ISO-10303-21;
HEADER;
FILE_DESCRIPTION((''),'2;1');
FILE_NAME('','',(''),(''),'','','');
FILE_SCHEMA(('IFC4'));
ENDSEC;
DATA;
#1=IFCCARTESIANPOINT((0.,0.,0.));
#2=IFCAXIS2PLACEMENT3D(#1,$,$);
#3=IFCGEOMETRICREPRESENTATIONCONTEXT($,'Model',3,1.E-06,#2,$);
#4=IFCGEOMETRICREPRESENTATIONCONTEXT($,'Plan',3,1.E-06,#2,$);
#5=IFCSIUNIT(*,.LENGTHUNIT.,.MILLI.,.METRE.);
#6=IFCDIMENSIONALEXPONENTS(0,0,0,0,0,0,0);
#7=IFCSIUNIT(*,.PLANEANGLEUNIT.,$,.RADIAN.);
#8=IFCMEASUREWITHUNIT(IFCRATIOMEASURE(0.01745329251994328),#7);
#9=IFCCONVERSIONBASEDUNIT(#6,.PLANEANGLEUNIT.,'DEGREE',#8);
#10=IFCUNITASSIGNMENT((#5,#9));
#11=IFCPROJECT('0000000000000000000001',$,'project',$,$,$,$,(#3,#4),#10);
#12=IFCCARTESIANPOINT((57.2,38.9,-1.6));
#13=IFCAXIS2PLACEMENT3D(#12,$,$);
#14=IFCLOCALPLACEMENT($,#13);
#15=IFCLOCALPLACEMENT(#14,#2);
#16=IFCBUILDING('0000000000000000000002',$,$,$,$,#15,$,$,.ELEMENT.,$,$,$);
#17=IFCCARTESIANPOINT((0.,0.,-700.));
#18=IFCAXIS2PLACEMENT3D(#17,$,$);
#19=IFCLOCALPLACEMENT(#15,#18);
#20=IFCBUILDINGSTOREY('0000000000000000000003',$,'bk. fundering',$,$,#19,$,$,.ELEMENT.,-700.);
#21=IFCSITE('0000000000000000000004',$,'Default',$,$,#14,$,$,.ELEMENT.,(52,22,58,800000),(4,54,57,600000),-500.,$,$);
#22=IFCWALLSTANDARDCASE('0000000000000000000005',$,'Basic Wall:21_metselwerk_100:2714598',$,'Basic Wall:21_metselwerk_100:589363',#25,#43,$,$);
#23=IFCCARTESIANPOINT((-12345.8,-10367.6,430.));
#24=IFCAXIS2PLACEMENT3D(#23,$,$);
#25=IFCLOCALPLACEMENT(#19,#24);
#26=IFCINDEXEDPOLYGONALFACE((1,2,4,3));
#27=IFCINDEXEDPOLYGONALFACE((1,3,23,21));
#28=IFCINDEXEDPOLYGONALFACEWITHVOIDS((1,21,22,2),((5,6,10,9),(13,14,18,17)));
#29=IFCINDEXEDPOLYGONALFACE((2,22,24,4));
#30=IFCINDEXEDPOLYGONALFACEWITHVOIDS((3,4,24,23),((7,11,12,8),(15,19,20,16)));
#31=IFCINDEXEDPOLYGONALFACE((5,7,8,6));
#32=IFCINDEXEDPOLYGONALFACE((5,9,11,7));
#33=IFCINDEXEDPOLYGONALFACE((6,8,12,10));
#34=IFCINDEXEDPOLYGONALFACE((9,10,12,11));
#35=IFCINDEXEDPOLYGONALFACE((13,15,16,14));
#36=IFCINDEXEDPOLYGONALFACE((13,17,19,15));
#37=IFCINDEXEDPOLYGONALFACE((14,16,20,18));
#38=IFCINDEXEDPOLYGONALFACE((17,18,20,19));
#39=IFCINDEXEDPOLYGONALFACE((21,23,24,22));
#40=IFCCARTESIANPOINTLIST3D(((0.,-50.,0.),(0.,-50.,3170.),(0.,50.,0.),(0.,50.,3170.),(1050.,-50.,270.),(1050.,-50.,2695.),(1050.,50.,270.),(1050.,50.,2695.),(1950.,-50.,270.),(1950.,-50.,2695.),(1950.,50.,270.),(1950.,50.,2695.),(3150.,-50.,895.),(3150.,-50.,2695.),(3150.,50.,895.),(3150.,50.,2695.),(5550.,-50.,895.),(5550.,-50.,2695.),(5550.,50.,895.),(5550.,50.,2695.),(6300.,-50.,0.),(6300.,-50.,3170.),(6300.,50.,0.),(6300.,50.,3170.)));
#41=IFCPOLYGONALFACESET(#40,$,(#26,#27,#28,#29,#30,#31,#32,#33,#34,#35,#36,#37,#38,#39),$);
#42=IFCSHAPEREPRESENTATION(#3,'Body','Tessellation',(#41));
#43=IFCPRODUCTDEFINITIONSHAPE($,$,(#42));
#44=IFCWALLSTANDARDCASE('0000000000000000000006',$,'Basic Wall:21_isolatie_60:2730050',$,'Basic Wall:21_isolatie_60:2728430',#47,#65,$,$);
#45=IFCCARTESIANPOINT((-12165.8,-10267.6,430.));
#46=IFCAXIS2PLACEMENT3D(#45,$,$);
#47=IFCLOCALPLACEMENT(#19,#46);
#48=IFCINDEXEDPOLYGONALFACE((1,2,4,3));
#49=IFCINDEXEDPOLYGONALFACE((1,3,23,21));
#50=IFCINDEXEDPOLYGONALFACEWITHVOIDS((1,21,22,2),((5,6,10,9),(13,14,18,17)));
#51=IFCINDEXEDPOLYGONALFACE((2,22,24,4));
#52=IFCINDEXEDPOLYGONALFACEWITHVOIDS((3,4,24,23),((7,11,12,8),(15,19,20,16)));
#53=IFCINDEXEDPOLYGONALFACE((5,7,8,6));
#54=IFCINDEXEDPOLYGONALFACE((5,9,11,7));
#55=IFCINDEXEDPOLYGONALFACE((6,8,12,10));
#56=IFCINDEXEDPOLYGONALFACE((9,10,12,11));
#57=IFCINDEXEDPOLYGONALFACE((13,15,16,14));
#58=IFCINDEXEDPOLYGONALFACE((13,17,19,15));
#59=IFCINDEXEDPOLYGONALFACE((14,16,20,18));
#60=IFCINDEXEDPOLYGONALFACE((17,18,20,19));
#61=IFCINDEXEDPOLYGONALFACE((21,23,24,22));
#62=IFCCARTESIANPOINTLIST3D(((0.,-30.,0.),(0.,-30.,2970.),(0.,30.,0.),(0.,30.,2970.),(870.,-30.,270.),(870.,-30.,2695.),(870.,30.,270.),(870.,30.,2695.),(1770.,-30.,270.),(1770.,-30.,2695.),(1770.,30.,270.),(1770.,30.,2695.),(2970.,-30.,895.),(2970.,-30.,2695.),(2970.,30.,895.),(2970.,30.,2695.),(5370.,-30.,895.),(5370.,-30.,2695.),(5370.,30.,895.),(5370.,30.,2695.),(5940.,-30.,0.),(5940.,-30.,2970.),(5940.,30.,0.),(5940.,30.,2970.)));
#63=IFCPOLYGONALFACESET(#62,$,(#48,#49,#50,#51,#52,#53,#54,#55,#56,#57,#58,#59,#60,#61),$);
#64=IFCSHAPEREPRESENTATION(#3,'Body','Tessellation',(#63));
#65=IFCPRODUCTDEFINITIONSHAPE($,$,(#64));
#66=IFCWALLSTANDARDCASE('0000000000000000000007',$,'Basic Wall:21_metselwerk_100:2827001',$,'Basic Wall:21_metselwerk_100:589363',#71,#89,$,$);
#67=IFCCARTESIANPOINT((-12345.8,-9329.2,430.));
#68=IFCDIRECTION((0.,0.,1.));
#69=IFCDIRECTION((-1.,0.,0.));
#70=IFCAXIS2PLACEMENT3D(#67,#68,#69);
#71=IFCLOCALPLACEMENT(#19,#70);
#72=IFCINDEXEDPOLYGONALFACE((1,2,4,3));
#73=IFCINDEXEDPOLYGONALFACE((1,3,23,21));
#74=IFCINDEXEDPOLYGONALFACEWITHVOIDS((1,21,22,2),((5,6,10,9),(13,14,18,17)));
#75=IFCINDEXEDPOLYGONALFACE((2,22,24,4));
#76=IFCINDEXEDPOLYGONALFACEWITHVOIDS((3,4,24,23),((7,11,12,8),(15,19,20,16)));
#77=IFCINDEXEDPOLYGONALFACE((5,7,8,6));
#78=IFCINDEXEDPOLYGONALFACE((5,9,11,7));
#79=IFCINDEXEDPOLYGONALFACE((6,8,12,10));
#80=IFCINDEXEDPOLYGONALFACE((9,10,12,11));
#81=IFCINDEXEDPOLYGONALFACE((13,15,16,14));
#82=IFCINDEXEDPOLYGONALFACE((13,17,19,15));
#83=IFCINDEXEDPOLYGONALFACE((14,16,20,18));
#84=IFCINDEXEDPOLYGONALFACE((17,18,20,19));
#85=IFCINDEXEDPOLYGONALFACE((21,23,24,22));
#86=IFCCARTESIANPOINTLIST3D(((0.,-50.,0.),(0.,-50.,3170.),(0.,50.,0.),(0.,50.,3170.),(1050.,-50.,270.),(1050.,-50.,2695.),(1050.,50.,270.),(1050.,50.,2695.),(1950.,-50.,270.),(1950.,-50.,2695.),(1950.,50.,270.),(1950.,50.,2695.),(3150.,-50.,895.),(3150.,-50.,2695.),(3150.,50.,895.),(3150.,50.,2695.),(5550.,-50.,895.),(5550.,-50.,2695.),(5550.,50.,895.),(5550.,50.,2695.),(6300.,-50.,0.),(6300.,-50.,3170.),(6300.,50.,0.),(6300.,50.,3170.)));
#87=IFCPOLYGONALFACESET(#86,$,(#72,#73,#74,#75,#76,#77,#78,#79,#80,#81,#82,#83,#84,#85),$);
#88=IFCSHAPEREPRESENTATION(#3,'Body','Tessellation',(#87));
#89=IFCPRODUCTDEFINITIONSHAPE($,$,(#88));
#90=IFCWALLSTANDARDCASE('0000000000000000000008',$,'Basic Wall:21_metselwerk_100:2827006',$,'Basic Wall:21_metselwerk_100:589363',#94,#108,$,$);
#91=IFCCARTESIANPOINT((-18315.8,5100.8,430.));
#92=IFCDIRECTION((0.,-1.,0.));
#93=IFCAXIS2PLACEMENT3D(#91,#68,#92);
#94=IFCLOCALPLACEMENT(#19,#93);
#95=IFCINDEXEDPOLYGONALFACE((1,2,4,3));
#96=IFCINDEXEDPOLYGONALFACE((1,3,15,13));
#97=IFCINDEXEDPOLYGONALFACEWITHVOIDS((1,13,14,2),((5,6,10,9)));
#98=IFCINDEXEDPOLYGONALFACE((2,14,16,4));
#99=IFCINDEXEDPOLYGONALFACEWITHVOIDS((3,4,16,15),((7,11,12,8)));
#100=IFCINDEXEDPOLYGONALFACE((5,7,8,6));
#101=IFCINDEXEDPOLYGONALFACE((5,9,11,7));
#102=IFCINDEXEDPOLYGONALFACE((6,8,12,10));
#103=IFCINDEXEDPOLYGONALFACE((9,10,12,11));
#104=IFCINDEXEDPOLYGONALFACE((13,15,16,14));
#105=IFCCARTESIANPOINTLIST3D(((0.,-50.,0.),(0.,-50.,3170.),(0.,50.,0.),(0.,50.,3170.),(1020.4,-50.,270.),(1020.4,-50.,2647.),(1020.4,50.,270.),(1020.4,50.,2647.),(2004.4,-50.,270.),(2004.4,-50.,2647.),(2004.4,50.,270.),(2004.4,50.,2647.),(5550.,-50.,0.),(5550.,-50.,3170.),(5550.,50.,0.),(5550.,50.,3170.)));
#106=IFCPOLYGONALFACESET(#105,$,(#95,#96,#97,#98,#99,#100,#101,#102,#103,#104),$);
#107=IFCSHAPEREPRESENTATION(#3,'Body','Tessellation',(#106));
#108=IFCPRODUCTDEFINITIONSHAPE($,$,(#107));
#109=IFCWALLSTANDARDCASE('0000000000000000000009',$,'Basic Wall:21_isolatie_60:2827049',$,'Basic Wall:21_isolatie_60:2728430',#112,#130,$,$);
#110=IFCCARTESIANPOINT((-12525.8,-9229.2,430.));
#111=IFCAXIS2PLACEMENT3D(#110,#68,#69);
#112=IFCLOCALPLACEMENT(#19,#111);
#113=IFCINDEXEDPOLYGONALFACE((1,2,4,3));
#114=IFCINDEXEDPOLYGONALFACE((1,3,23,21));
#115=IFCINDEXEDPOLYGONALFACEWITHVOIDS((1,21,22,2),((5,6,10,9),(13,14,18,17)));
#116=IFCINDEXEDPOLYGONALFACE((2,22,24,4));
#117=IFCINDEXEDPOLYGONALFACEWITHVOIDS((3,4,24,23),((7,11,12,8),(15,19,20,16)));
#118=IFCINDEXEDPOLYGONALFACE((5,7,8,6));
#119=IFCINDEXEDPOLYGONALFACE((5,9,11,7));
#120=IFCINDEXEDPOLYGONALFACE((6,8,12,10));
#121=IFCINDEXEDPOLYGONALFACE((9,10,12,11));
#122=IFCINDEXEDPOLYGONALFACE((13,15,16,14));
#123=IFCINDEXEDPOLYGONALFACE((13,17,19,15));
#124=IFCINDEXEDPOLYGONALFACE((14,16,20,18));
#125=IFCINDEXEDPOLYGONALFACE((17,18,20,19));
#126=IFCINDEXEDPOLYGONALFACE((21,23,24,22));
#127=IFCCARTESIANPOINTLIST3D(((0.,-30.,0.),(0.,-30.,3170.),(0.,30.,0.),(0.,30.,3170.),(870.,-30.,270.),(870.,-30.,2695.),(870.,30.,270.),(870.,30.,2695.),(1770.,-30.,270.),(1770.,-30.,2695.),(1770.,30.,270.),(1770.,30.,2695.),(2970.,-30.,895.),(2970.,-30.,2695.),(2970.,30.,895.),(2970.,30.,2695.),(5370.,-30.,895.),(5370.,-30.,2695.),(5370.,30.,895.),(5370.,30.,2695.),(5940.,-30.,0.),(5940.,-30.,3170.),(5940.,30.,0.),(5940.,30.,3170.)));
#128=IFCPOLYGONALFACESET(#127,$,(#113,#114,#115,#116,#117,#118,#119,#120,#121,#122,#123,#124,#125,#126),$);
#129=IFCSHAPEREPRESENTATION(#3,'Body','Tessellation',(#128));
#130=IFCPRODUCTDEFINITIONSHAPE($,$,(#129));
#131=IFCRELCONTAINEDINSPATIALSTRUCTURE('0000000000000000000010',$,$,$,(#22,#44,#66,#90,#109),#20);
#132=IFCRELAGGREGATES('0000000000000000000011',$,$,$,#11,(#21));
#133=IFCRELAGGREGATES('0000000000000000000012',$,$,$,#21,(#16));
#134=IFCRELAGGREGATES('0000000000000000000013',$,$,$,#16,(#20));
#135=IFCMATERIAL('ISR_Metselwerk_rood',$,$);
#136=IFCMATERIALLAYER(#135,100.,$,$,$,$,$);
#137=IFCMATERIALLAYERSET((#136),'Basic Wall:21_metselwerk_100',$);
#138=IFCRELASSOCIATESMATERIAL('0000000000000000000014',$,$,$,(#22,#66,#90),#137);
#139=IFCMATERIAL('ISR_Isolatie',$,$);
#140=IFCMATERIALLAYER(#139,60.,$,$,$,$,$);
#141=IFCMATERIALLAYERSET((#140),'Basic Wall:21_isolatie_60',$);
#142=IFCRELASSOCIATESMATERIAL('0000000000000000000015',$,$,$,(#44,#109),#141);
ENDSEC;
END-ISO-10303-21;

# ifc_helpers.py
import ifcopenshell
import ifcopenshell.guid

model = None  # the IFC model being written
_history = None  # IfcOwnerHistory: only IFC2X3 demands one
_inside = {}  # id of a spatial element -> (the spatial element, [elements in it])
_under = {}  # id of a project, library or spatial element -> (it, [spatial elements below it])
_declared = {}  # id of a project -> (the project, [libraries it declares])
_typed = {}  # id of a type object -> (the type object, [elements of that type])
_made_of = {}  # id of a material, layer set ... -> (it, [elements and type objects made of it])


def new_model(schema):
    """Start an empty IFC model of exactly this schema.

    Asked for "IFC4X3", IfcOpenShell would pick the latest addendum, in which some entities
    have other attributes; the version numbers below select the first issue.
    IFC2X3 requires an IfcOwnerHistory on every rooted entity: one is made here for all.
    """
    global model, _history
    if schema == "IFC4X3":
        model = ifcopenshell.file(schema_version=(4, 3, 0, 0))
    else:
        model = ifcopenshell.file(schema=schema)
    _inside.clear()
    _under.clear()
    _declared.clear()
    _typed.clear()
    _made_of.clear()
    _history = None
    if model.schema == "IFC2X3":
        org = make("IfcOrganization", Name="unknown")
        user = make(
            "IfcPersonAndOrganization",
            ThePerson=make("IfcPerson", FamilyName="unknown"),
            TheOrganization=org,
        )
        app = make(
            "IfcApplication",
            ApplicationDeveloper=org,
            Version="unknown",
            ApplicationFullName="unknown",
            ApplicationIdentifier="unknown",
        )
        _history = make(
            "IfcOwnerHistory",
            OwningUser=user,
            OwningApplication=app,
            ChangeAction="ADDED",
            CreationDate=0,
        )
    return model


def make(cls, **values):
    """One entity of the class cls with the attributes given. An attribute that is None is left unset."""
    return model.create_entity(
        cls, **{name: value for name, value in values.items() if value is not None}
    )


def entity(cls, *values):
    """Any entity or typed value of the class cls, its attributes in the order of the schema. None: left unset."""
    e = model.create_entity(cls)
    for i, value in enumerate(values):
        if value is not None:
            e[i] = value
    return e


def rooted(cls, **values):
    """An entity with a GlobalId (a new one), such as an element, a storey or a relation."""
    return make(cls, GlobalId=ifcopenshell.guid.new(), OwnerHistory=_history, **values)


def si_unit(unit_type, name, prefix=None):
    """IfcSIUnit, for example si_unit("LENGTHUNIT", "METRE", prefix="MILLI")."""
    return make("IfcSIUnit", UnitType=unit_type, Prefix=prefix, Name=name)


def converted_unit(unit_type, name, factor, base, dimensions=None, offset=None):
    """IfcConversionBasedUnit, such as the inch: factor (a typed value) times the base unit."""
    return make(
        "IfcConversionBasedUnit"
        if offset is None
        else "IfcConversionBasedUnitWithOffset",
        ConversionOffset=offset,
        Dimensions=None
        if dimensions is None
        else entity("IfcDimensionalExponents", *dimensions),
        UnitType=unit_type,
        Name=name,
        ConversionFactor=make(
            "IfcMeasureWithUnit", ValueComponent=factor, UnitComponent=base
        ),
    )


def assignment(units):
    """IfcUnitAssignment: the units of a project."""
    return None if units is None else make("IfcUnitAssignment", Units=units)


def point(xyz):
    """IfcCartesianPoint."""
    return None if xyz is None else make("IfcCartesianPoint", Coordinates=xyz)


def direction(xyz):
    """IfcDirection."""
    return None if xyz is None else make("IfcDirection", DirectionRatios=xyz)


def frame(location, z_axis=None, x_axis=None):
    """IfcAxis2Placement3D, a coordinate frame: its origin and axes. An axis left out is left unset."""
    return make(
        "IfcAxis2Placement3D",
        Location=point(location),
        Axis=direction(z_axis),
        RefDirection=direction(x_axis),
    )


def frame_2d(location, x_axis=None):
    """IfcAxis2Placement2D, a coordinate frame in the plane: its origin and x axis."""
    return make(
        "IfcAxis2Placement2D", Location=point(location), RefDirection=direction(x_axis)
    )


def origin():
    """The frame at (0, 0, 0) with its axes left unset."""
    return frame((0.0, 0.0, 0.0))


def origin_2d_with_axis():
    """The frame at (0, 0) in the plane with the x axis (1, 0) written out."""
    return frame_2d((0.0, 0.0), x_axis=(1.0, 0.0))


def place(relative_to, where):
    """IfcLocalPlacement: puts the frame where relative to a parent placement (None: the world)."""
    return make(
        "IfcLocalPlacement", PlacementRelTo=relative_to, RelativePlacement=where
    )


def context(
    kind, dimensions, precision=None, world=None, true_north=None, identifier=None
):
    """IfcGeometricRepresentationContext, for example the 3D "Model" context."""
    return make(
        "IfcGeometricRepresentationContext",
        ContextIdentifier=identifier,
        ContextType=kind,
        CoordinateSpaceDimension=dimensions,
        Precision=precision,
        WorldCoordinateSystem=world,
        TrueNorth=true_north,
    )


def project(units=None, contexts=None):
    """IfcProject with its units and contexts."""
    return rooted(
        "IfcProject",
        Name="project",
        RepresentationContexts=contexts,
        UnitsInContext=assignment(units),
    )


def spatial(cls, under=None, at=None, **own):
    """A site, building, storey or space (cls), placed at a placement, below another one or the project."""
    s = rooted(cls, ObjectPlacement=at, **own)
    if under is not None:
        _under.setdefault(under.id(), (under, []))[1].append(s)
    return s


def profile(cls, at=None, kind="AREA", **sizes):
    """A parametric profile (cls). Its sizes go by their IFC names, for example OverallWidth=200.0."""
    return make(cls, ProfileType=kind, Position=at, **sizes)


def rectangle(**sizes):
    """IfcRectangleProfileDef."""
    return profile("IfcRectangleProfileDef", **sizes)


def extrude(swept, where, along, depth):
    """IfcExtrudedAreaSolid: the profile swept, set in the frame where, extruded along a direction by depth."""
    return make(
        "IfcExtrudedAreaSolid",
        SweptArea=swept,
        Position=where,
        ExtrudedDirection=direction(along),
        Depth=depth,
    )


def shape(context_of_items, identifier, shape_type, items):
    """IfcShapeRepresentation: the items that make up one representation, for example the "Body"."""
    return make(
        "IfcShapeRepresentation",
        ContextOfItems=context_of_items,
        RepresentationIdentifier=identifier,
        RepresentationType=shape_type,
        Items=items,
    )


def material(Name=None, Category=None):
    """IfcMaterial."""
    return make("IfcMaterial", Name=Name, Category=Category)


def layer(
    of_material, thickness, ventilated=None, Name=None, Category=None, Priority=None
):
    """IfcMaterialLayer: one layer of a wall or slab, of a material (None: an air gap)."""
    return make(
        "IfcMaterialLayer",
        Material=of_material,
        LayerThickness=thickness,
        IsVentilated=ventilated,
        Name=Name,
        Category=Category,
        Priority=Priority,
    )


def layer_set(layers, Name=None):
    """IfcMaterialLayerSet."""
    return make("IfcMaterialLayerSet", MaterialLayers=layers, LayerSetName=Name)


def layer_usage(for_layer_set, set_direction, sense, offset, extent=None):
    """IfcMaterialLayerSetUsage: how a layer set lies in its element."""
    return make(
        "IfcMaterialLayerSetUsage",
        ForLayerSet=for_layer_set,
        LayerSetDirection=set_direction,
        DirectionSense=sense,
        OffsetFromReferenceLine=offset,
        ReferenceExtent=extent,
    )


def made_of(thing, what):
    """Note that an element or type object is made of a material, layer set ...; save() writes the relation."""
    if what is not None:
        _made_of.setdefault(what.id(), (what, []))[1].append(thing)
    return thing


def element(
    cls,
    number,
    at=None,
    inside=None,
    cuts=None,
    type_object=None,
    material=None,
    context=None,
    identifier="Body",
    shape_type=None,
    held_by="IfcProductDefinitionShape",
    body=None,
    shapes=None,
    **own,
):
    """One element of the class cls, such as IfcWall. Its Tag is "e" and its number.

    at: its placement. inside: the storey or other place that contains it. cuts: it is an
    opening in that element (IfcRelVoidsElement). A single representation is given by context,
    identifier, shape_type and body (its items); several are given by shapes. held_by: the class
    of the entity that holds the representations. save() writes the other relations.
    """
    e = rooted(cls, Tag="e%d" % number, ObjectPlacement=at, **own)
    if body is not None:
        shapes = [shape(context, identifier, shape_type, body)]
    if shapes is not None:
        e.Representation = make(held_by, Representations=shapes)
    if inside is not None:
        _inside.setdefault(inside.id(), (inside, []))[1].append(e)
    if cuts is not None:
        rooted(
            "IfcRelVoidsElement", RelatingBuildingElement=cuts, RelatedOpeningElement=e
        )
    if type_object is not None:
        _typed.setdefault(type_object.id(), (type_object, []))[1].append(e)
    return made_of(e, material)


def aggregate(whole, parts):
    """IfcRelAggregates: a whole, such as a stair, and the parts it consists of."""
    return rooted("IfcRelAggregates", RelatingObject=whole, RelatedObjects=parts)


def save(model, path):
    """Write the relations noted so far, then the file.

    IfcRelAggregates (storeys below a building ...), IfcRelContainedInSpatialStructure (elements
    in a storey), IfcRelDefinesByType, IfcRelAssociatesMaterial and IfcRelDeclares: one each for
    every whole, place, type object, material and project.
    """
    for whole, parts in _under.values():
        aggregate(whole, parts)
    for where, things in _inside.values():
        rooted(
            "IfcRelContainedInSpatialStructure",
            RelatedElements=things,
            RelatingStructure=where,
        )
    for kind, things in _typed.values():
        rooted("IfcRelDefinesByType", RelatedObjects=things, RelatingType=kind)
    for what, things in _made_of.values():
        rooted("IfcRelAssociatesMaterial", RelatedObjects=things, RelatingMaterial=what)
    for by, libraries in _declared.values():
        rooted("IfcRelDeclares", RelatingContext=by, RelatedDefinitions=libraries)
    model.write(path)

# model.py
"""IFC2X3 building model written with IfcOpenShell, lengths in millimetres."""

from ifc_helpers import new_model, entity, si_unit, converted_unit, frame, frame_2d, origin, origin_2d_with_axis, place, context, project, spatial, rectangle, extrude, material, layer, layer_set, layer_usage, element, save


model = new_model("IFC2X3")

# Units and contexts
model_context = context("Model", 3, precision=1e-06, world=origin())
plan_context = context("Plan", 3, precision=1e-06, world=origin())
ifc_project = project(units=[si_unit("LENGTHUNIT", "METRE", prefix="MILLI"), converted_unit("PLANEANGLEUNIT", "DEGREE", entity("IfcRatioMeasure", 0.01745329251994328), si_unit("PLANEANGLEUNIT", "RADIAN"), dimensions=[0, 0, 0, 0, 0, 0, 0])], contexts=[model_context, plan_context])

# Site, building, storey
site_placement = place(None, frame((57.2, 38.9, -1.6)))
site = spatial("IfcSite", under=ifc_project, at=site_placement, Name="Default", CompositionType="ELEMENT", RefLatitude=(52, 22, 58, 800000), RefLongitude=(4, 54, 57, 600000), RefElevation=-500.0)
building_placement = place(site_placement, origin())
building = spatial("IfcBuilding", under=site, at=building_placement, CompositionType="ELEMENT")
storey_placement = place(building_placement, frame((0.0, 0.0, -700.0)))
storey = spatial("IfcBuildingStorey", under=building, at=storey_placement, Name="bk. fundering", CompositionType="ELEMENT", Elevation=-700.0)

# Wall, openings
ifc_material_1 = material(Name="ISR_Metselwerk_rood")
ifc_layer_1 = layer(ifc_material_1, 100.0)
ifc_layer_set_1 = layer_set([ifc_layer_1], Name="Basic Wall:21_metselwerk_100")
ifc_layer_usage_1 = layer_usage(ifc_layer_set_1, "AXIS2", "NEGATIVE", 50.0)
wall_1_placement = place(storey_placement, frame((-12345.8, -10367.6, 430.0)))
wall_1 = element("IfcWallStandardCase", 1, at=wall_1_placement, inside=storey, material=ifc_layer_usage_1, Name="Basic Wall:21_metselwerk_100:2714598", ObjectType="Basic Wall:21_metselwerk_100:589363", context=model_context, shape_type="SweptSolid", body=[
    extrude(rectangle(XDim=6300.0, YDim=100.0, at=frame_2d((3150.0, 0.0), x_axis=(-1.0, 0.0))), origin(), (0.0, 0.0, 1.0), 3170.0),
])
opening_1_placement = place(wall_1_placement, origin())
element("IfcOpeningElement", 2, at=opening_1_placement, cuts=wall_1, ObjectType="Opening", context=model_context, shape_type="SweptSolid", body=[
    extrude(rectangle(XDim=2425.0, YDim=900.0, at=origin_2d_with_axis()), frame((1500.0, -202.4, 1482.5), z_axis=(0.0, 1.0, 0.0), x_axis=(0.0, 0.0, 1.0)), (0.0, 0.0, 1.0), 404.8),
])
opening_2_placement = place(wall_1_placement, origin())
element("IfcOpeningElement", 3, at=opening_2_placement, cuts=wall_1, ObjectType="Opening", context=model_context, shape_type="SweptSolid", body=[
    extrude(rectangle(XDim=1800.0, YDim=2400.0, at=origin_2d_with_axis()), frame((4350.0, -202.4, 1795.0), z_axis=(0.0, 1.0, 0.0), x_axis=(0.0, 0.0, 1.0)), (0.0, 0.0, 1.0), 404.8),
])

# Shared definitions
ifc_material_2 = material(Name="ISR_Isolatie")
ifc_layer_2 = layer(ifc_material_2, 60.0)
ifc_layer_set_2 = layer_set([ifc_layer_2], Name="Basic Wall:21_isolatie_60")

# Wall, openings
ifc_layer_usage_2 = layer_usage(ifc_layer_set_2, "AXIS2", "NEGATIVE", 30.0)
wall_2_placement = place(storey_placement, frame((-12165.8, -10267.6, 430.0)))
wall_2 = element("IfcWallStandardCase", 4, at=wall_2_placement, inside=storey, material=ifc_layer_usage_2, Name="Basic Wall:21_isolatie_60:2730050", ObjectType="Basic Wall:21_isolatie_60:2728430", context=model_context, shape_type="SweptSolid", body=[
    extrude(rectangle(XDim=5940.0, YDim=60.0, at=frame_2d((2970.0, 0.0), x_axis=(-1.0, 0.0))), origin(), (0.0, 0.0, 1.0), 2970.0),
])
opening_3_placement = place(wall_2_placement, origin())
element("IfcOpeningElement", 5, at=opening_3_placement, cuts=wall_2, ObjectType="Opening", context=model_context, shape_type="SweptSolid", body=[
    extrude(rectangle(XDim=2425.0, YDim=900.0, at=origin_2d_with_axis()), frame((1320.0, -182.4, 1482.5), z_axis=(0.0, 1.0, 0.0), x_axis=(0.0, 0.0, 1.0)), (0.0, 0.0, 1.0), 364.8),
])
opening_4_placement = place(wall_2_placement, origin())
element("IfcOpeningElement", 6, at=opening_4_placement, cuts=wall_2, ObjectType="Opening", context=model_context, shape_type="SweptSolid", body=[
    extrude(rectangle(XDim=1800.0, YDim=2400.0, at=origin_2d_with_axis()), frame((4170.0, -182.4, 1795.0), z_axis=(0.0, 1.0, 0.0), x_axis=(0.0, 0.0, 1.0)), (0.0, 0.0, 1.0), 364.8),
])

# Wall, openings
ifc_layer_usage_3 = layer_usage(ifc_layer_set_1, "AXIS2", "POSITIVE", -50.0)
wall_3_placement = place(storey_placement, frame((-12345.8, -9329.2, 430.0), z_axis=(0.0, 0.0, 1.0), x_axis=(-1.0, 0.0, 0.0)))
wall_3 = element("IfcWallStandardCase", 7, at=wall_3_placement, inside=storey, material=ifc_layer_usage_3, Name="Basic Wall:21_metselwerk_100:2827001", ObjectType="Basic Wall:21_metselwerk_100:589363", context=model_context, shape_type="SweptSolid", body=[
    extrude(rectangle(XDim=6300.0, YDim=100.0, at=frame_2d((3150.0, 0.0), x_axis=(-1.0, 0.0))), origin(), (0.0, 0.0, 1.0), 3170.0),
])
opening_5_placement = place(wall_3_placement, origin())
element("IfcOpeningElement", 8, at=opening_5_placement, cuts=wall_3, ObjectType="Opening", context=model_context, shape_type="SweptSolid", body=[
    extrude(rectangle(XDim=2425.0, YDim=900.0, at=origin_2d_with_axis()), frame((1500.0, -202.4, 1482.5), z_axis=(0.0, 1.0, 0.0), x_axis=(0.0, 0.0, 1.0)), (0.0, 0.0, 1.0), 404.8),
])
opening_6_placement = place(wall_3_placement, origin())
element("IfcOpeningElement", 9, at=opening_6_placement, cuts=wall_3, ObjectType="Opening", context=model_context, shape_type="SweptSolid", body=[
    extrude(rectangle(XDim=1800.0, YDim=2400.0, at=origin_2d_with_axis()), frame((4350.0, -202.4, 1795.0), z_axis=(0.0, 1.0, 0.0), x_axis=(0.0, 0.0, 1.0)), (0.0, 0.0, 1.0), 404.8),
])

# Wall, opening
ifc_layer_usage_4 = layer_usage(ifc_layer_set_1, "AXIS2", "POSITIVE", -50.0)
wall_4_placement = place(storey_placement, frame((-18315.8, 5100.8, 430.0), z_axis=(0.0, 0.0, 1.0), x_axis=(0.0, -1.0, 0.0)))
wall_4 = element("IfcWallStandardCase", 10, at=wall_4_placement, inside=storey, material=ifc_layer_usage_4, Name="Basic Wall:21_metselwerk_100:2827006", ObjectType="Basic Wall:21_metselwerk_100:589363", context=model_context, shape_type="SweptSolid", body=[
    extrude(rectangle(XDim=5550.0, YDim=100.0, at=frame_2d((2775.0, 0.0), x_axis=(-1.0, 0.0))), origin(), (0.0, 0.0, 1.0), 3170.0),
])
opening_7_placement = place(wall_4_placement, origin())
element("IfcOpeningElement", 11, at=opening_7_placement, cuts=wall_4, ObjectType="Opening", context=model_context, shape_type="SweptSolid", body=[
    extrude(rectangle(XDim=2377.0, YDim=984.0, at=frame_2d((0.0, 0.0), x_axis=(0.0, 1.0))), frame((1512.4, -1654.0, 1458.5), z_axis=(0.0, 1.0, 0.0), x_axis=(-1.0, 0.0, 0.0)), (0.0, 0.0, 1.0), 3048.0),
])

# Wall, openings
ifc_layer_usage_5 = layer_usage(ifc_layer_set_2, "AXIS2", "POSITIVE", -30.0)
wall_5_placement = place(storey_placement, frame((-12525.8, -9229.2, 430.0), z_axis=(0.0, 0.0, 1.0), x_axis=(-1.0, 0.0, 0.0)))
wall_5 = element("IfcWallStandardCase", 12, at=wall_5_placement, inside=storey, material=ifc_layer_usage_5, Name="Basic Wall:21_isolatie_60:2827049", ObjectType="Basic Wall:21_isolatie_60:2728430", context=model_context, shape_type="SweptSolid", body=[
    extrude(rectangle(XDim=5940.0, YDim=60.0, at=frame_2d((2970.0, 0.0), x_axis=(-1.0, 0.0))), origin(), (0.0, 0.0, 1.0), 3170.0),
])
opening_8_placement = place(wall_5_placement, origin())
element("IfcOpeningElement", 13, at=opening_8_placement, cuts=wall_5, ObjectType="Opening", context=model_context, shape_type="SweptSolid", body=[
    extrude(rectangle(XDim=2425.0, YDim=900.0, at=origin_2d_with_axis()), frame((1320.0, -182.4, 1482.5), z_axis=(0.0, 1.0, 0.0), x_axis=(0.0, 0.0, 1.0)), (0.0, 0.0, 1.0), 364.8),
])
opening_9_placement = place(wall_5_placement, origin())
element("IfcOpeningElement", 14, at=opening_9_placement, cuts=wall_5, ObjectType="Opening", context=model_context, shape_type="SweptSolid", body=[
    extrude(rectangle(XDim=1800.0, YDim=2400.0, at=origin_2d_with_axis()), frame((4170.0, -182.4, 1795.0), z_axis=(0.0, 1.0, 0.0), x_axis=(0.0, 0.0, 1.0)), (0.0, 0.0, 1.0), 364.8),
])

save(model, "model.ifc")
